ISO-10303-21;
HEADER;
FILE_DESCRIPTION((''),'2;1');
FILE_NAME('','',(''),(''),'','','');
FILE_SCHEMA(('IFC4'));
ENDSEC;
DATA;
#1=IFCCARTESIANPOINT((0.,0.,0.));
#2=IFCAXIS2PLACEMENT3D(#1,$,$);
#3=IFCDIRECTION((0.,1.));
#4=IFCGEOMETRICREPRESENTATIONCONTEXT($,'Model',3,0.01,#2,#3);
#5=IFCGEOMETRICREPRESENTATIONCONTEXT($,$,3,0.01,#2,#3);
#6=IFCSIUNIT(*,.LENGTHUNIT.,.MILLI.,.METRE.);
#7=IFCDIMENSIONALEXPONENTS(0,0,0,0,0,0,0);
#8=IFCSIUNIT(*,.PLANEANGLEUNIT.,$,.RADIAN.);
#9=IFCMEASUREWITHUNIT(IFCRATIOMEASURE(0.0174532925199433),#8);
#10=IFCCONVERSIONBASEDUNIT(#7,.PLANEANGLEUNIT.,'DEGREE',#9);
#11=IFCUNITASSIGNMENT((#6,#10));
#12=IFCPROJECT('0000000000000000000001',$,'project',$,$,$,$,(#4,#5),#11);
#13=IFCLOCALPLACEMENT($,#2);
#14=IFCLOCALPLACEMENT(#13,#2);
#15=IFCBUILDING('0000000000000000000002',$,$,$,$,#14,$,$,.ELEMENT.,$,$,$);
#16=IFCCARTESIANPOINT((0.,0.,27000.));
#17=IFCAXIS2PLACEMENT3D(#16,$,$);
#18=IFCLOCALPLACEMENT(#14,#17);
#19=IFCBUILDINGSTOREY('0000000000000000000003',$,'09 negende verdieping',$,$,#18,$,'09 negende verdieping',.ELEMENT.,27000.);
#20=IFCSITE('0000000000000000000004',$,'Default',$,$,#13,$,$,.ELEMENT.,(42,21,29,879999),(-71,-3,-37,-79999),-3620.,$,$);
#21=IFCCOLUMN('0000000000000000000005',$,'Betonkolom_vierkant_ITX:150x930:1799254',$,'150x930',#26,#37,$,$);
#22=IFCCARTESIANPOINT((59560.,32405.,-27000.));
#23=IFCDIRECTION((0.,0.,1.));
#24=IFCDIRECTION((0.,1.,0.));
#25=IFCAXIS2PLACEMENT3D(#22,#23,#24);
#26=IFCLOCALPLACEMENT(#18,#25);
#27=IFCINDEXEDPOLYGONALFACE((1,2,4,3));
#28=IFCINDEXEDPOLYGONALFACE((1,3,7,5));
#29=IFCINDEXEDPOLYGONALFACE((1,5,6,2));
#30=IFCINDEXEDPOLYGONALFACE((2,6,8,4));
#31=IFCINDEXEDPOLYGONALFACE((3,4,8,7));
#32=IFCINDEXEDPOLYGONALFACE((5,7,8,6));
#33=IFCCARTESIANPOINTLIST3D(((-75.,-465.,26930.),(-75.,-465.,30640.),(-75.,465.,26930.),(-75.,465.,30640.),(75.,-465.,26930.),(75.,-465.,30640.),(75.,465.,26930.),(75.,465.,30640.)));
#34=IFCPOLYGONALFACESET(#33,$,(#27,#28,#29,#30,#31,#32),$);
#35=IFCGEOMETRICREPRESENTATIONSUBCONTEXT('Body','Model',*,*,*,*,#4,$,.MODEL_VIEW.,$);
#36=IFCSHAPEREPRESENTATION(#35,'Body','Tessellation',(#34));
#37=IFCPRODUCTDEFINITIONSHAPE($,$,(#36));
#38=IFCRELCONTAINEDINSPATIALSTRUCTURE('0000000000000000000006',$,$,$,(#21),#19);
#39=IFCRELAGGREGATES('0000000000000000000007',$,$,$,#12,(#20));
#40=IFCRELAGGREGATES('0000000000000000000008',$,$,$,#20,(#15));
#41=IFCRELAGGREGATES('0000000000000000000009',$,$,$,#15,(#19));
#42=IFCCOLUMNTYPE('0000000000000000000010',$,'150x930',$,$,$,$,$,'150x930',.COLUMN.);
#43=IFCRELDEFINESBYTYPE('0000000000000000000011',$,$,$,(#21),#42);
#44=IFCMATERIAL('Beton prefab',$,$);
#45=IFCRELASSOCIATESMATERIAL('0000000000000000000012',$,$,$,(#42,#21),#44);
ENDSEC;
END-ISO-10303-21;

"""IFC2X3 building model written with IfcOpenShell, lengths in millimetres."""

from ifc_helpers import new_model, entity, si_unit, converted_unit, direction, frame, origin, origin_2d_with_axis, place, context, subcontext, project, spatial, rectangle, extrude, source, transform, mapped, material, type_object, type_shapes, element, save


model = new_model("IFC2X3")

# Units and contexts
model_context = context("Model", 3, precision=0.01, world=origin(), true_north=direction((0.0, 1.0)))
context_of_model = context(None, 3, precision=0.01, world=origin(), true_north=direction((0.0, 1.0)))
body_context = subcontext(model_context, "Body", "Model", "MODEL_VIEW")
ifc_project = project(units=[si_unit("LENGTHUNIT", "METRE", prefix="MILLI"), converted_unit("PLANEANGLEUNIT", "DEGREE", entity("IfcRatioMeasure", 0.0174532925199433), si_unit("PLANEANGLEUNIT", "RADIAN"), dimensions=[0, 0, 0, 0, 0, 0, 0])], contexts=[model_context, context_of_model])

# Site, building, storey
site_placement = place(None, origin())
site = spatial("IfcSite", under=ifc_project, at=site_placement, Name="Default", CompositionType="ELEMENT", RefLatitude=(42, 21, 29, 879999), RefLongitude=(-71, -3, -37, -79999), RefElevation=-3620.0)
building_placement = place(site_placement, origin())
building = spatial("IfcBuilding", under=site, at=building_placement, CompositionType="ELEMENT")
storey_placement = place(building_placement, frame((0.0, 0.0, 27000.0)))
storey = spatial("IfcBuildingStorey", under=building, at=storey_placement, Name="09 negende verdieping", LongName="09 negende verdieping", CompositionType="ELEMENT", Elevation=27000.0)

# Column
ifc_material_1 = material(Name="Beton prefab")
column_type = type_object("IfcColumnType", Name="150x930", ElementType="150x930", PredefinedType="COLUMN", material=ifc_material_1)
shared_shape = source(origin(), body_context, "Body", "SweptSolid", [
    extrude(rectangle(XDim=930.0, YDim=150.0, at=origin_2d_with_axis()), frame((0.0, 0.0, 26930.0), z_axis=(0.0, 0.0, 1.0), x_axis=(0.0, -1.0, 0.0)), (0.0, 0.0, 1.0), 3710.0),
])
type_shapes(column_type, [shared_shape])
column_placement = place(storey_placement, frame((59560.0, 32405.0, -27000.0), z_axis=(0.0, 0.0, 1.0), x_axis=(0.0, 1.0, 0.0)))
element("IfcColumn", 1, at=column_placement, inside=storey, type_object=column_type, material=ifc_material_1, Name="Betonkolom_vierkant_ITX:150x930:1799254", ObjectType="150x930", context=body_context, shape_type="MappedRepresentation", body=[
    mapped(shared_shape, transform((0.0, 0.0, 0.0), scale=1.0)),
])

save(model, "model.ifc")
